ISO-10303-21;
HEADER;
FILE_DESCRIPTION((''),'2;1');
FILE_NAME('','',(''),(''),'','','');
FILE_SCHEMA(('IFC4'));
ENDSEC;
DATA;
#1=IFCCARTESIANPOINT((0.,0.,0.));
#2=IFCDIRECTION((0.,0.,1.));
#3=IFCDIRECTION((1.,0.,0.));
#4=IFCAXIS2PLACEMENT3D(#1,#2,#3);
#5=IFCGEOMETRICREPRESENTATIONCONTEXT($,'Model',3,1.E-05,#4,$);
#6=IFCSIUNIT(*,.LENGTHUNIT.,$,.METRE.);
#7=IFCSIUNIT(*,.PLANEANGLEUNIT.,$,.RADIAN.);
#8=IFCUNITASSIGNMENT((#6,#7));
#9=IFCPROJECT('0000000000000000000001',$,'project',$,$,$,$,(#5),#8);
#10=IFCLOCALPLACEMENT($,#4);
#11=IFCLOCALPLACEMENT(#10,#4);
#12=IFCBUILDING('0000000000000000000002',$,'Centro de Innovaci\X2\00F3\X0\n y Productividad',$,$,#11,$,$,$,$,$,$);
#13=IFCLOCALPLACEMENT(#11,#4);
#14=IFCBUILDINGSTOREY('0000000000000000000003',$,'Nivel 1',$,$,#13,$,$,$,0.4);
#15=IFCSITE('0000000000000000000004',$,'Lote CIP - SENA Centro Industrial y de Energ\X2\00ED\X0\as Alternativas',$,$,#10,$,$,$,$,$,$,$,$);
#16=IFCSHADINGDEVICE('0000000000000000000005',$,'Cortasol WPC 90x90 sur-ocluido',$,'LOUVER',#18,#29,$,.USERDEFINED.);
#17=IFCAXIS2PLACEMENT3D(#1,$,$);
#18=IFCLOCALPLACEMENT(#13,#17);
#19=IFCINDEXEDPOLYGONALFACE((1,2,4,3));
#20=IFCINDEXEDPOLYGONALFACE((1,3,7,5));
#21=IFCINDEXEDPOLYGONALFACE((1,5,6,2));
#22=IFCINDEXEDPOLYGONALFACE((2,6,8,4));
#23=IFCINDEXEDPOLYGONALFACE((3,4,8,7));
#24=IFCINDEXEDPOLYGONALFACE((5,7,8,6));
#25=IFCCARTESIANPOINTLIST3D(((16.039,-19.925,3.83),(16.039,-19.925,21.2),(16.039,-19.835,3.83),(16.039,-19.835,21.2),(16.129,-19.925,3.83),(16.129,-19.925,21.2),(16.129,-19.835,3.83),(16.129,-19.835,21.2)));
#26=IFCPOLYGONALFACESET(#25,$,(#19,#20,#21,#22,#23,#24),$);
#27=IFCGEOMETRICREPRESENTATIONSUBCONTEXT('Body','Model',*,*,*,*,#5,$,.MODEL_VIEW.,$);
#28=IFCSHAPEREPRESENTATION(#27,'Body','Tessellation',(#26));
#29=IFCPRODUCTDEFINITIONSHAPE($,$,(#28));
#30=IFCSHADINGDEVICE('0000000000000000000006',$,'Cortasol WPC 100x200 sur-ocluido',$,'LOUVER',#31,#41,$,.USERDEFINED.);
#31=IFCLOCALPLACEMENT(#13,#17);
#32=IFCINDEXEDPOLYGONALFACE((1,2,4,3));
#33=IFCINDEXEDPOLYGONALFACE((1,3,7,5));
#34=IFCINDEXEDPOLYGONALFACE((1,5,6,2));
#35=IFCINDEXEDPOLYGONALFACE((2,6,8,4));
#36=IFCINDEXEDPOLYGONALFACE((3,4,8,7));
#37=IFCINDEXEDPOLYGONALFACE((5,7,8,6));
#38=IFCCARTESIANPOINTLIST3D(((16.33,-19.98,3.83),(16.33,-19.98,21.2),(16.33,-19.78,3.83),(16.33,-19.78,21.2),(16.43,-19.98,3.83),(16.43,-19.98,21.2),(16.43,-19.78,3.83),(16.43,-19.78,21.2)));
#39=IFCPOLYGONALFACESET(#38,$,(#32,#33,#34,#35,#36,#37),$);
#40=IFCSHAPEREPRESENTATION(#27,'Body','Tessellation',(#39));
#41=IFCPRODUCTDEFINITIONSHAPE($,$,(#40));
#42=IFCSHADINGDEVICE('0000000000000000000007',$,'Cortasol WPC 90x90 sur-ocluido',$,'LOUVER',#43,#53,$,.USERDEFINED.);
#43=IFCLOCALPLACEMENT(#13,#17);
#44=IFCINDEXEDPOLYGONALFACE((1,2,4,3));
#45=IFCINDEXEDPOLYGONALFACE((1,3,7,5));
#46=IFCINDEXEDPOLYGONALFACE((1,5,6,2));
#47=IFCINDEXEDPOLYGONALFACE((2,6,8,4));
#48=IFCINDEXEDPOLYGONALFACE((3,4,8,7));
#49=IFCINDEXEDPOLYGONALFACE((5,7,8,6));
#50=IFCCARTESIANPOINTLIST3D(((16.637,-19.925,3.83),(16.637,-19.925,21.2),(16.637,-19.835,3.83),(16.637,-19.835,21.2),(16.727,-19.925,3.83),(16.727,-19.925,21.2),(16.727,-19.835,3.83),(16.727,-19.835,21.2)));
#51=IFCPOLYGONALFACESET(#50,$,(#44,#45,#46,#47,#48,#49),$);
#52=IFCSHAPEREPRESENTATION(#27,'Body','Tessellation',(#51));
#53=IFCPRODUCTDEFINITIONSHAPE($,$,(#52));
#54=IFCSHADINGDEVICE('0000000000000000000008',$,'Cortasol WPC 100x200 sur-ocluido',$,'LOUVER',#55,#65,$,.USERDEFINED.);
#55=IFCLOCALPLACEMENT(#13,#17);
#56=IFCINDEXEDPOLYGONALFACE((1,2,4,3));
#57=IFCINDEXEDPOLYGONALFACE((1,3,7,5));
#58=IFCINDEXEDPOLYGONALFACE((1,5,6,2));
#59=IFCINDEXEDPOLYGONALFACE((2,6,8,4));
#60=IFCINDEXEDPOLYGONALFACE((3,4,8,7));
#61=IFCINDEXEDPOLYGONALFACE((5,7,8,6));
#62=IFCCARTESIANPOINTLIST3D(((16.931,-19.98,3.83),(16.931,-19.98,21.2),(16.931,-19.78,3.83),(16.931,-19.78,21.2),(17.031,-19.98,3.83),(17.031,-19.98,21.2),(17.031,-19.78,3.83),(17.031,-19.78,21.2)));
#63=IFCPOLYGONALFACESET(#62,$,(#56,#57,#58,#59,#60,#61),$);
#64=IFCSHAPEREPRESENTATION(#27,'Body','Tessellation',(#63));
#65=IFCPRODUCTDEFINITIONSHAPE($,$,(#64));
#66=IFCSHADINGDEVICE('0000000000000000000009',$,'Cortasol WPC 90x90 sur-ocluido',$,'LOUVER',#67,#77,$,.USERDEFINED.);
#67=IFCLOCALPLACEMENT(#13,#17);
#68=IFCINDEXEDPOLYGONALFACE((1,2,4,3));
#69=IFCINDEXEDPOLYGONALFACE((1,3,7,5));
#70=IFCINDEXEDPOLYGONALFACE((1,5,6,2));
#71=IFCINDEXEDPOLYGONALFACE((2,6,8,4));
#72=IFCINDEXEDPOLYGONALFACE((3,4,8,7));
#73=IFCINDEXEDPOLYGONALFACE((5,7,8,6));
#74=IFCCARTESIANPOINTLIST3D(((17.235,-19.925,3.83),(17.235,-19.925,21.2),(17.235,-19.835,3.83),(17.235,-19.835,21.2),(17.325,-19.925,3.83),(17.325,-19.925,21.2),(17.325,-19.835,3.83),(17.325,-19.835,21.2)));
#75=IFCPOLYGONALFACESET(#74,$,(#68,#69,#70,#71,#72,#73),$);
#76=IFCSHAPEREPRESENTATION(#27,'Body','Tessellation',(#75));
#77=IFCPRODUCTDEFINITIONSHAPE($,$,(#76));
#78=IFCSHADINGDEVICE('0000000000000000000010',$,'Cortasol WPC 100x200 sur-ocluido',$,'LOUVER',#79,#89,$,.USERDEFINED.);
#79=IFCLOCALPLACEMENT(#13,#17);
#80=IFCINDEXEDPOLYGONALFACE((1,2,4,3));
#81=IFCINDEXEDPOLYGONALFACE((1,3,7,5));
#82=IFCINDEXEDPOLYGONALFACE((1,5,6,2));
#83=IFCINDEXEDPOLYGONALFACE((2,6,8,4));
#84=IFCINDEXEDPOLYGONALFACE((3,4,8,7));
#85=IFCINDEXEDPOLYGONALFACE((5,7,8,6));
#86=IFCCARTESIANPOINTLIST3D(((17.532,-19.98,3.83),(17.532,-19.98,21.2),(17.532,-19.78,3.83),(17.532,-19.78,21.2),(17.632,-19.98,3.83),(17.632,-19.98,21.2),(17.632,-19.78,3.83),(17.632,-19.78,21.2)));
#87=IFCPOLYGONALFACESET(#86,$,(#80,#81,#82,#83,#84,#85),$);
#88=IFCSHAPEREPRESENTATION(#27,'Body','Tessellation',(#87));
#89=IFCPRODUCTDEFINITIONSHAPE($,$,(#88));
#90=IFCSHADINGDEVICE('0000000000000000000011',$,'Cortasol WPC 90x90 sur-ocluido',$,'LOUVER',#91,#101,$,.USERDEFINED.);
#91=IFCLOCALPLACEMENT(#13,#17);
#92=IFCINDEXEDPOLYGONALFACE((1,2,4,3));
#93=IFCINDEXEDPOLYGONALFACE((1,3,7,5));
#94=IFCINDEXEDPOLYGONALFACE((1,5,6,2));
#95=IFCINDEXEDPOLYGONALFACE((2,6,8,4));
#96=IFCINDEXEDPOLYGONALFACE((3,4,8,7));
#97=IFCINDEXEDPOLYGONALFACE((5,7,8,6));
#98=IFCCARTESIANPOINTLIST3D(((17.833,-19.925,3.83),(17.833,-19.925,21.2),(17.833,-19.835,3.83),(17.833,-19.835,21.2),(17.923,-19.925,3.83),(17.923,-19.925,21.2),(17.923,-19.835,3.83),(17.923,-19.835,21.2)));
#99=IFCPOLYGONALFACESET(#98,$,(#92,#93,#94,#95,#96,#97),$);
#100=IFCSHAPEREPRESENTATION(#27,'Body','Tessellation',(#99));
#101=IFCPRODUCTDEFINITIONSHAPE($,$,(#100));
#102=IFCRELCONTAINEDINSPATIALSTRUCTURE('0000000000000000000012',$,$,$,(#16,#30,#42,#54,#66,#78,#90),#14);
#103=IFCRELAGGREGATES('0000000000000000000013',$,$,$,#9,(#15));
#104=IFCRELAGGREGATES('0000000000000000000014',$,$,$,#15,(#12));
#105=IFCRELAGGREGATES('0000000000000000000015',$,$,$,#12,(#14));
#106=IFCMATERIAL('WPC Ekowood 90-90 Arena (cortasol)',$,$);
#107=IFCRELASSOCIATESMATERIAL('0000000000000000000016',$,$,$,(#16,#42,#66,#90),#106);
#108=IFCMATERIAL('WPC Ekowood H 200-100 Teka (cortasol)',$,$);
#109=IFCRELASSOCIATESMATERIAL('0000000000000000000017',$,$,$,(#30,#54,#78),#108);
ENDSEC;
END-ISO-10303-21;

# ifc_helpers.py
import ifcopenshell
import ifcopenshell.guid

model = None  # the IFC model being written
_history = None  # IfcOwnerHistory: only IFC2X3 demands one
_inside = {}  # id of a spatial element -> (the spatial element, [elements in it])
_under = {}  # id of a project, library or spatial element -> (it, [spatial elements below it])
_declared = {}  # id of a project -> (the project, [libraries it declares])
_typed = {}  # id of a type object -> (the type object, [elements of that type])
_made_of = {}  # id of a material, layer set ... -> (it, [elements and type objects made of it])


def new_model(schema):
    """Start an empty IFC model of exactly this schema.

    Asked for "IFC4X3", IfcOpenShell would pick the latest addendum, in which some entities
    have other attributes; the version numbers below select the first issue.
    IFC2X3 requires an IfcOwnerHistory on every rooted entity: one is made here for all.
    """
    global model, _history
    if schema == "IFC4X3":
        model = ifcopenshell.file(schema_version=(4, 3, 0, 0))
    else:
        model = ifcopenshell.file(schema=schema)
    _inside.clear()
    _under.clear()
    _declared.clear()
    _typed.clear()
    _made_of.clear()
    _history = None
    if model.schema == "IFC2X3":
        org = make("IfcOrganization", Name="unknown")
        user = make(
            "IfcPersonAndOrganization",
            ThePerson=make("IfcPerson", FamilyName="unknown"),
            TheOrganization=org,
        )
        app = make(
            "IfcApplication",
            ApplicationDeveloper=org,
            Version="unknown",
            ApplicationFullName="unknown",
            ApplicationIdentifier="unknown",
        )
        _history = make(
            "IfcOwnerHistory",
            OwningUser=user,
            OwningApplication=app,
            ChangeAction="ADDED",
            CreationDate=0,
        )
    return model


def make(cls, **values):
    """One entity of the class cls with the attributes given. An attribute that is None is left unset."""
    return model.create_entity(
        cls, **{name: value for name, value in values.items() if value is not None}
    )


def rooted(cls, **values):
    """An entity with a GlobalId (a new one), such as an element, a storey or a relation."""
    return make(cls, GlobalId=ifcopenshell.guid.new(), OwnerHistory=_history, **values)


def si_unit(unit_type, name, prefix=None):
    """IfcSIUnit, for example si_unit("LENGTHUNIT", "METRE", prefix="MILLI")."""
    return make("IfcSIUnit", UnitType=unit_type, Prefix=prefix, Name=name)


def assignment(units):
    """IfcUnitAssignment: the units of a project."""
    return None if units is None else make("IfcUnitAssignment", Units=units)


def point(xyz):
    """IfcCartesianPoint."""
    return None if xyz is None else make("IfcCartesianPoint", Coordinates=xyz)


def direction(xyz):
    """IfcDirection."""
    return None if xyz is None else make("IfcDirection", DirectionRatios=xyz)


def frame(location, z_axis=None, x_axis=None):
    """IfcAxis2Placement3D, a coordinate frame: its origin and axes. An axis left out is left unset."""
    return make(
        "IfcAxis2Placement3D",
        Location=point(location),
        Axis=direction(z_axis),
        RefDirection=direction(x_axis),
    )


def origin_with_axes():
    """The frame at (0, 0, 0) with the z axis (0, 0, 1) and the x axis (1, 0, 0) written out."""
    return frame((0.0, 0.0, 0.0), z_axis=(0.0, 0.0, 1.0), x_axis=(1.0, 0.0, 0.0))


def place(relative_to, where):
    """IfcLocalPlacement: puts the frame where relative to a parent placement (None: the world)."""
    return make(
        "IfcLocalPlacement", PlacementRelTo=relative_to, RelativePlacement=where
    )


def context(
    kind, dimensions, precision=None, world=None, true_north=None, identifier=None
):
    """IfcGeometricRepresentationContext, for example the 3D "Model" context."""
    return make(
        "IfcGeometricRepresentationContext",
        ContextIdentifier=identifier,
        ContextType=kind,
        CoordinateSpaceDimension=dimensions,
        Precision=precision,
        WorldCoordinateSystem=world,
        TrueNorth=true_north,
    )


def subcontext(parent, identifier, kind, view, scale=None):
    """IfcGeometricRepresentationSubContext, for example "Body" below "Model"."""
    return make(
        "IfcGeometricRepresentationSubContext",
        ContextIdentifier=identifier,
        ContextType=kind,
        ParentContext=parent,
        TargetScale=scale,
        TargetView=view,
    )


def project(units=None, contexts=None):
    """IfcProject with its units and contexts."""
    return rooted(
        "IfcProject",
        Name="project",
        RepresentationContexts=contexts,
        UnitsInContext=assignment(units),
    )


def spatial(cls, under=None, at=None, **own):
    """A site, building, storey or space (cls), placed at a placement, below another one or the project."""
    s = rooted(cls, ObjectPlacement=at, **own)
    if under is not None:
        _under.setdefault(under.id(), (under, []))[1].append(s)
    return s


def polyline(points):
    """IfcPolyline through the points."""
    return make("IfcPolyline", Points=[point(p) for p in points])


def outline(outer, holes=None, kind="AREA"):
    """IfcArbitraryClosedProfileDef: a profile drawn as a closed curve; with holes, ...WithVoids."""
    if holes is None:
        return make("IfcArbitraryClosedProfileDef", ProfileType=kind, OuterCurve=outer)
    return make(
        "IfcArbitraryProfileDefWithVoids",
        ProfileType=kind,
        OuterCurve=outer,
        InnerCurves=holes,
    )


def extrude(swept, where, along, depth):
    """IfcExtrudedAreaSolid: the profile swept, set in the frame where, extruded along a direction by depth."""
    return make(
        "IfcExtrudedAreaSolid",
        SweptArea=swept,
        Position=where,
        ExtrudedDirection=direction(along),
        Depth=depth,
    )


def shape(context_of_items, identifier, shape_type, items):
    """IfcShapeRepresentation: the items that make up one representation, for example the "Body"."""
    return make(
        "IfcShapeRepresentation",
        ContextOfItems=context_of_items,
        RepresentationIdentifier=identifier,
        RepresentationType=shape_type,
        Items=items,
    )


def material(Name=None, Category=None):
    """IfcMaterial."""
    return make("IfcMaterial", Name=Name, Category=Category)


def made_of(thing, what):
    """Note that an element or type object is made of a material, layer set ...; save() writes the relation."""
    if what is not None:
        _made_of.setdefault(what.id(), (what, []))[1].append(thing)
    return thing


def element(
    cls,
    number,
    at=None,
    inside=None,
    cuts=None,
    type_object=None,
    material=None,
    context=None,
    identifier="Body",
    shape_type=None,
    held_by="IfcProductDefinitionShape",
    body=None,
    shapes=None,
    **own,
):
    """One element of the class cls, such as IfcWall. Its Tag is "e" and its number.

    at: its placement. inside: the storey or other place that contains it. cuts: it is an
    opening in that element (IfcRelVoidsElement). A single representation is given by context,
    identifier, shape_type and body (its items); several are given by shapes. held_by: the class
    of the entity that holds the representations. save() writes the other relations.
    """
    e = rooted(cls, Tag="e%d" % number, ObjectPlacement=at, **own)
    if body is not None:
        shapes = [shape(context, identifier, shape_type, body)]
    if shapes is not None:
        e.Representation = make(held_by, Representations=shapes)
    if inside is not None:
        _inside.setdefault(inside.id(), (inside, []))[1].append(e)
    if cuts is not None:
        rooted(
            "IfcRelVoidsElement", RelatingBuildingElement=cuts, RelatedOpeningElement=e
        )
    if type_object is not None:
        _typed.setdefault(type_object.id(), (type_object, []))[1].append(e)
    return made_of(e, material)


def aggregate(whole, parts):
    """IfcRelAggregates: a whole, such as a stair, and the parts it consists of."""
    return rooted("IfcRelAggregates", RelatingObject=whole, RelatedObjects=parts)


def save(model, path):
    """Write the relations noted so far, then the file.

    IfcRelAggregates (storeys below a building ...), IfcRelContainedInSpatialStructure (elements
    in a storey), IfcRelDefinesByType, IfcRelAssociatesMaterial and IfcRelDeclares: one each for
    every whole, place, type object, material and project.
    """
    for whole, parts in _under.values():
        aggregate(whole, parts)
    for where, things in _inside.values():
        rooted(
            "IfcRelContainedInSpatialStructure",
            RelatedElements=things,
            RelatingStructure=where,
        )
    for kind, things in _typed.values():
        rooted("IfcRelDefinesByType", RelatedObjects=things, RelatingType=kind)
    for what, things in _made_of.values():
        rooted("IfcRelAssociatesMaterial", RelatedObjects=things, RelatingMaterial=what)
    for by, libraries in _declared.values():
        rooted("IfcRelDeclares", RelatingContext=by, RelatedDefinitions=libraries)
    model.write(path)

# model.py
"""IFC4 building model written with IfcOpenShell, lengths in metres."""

from ifc_helpers import new_model, si_unit, frame, origin_with_axes, place, context, subcontext, project, spatial, polyline, outline, extrude, material, element, save


model = new_model("IFC4")

# Units and contexts
model_context = context("Model", 3, precision=1e-05, world=origin_with_axes())
body_context = subcontext(model_context, "Body", "Model", "MODEL_VIEW")
ifc_project = project(units=[si_unit("LENGTHUNIT", "METRE"), si_unit("PLANEANGLEUNIT", "RADIAN")], contexts=[model_context])

# Site, building, storey
site_placement = place(None, origin_with_axes())
site = spatial("IfcSite", under=ifc_project, at=site_placement, Name="Lote CIP - SENA Centro Industrial y de Energías Alternativas")
building_placement = place(site_placement, origin_with_axes())
building = spatial("IfcBuilding", under=site, at=building_placement, Name="Centro de Innovación y Productividad")
storey_placement = place(building_placement, origin_with_axes())
storey = spatial("IfcBuildingStorey", under=building, at=storey_placement, Name="Nivel 1", Elevation=0.4)

# Shading devices
ifc_material_1 = material(Name="WPC Ekowood H 200-100 Teka (cortasol)")
ifc_material_2 = material(Name="WPC Ekowood 90-90 Arena (cortasol)")
shading_device_1_placement = place(storey_placement, origin_with_axes())
element("IfcShadingDevice", 1, at=shading_device_1_placement, inside=storey, material=ifc_material_2, Name="Cortasol WPC 90x90 sur-ocluido", ObjectType="LOUVER", PredefinedType="USERDEFINED", context=body_context, shape_type="SweptSolid", body=[
    extrude(outline(polyline([(16.039, -19.925), (16.039, -19.835), (16.129, -19.835), (16.129, -19.925), (16.039, -19.925)])), frame((0.0, 0.0, 3.83)), (0.0, 0.0, 1.0), 17.37),
])
shading_device_2_placement = place(storey_placement, origin_with_axes())
element("IfcShadingDevice", 2, at=shading_device_2_placement, inside=storey, material=ifc_material_1, Name="Cortasol WPC 100x200 sur-ocluido", ObjectType="LOUVER", PredefinedType="USERDEFINED", context=body_context, shape_type="SweptSolid", body=[
    extrude(outline(polyline([(16.33, -19.98), (16.33, -19.78), (16.43, -19.78), (16.43, -19.98), (16.33, -19.98)])), frame((0.0, 0.0, 3.83)), (0.0, 0.0, 1.0), 17.37),
])
shading_device_3_placement = place(storey_placement, origin_with_axes())
element("IfcShadingDevice", 3, at=shading_device_3_placement, inside=storey, material=ifc_material_2, Name="Cortasol WPC 90x90 sur-ocluido", ObjectType="LOUVER", PredefinedType="USERDEFINED", context=body_context, shape_type="SweptSolid", body=[
    extrude(outline(polyline([(16.637, -19.925), (16.637, -19.835), (16.727, -19.835), (16.727, -19.925), (16.637, -19.925)])), frame((0.0, 0.0, 3.83)), (0.0, 0.0, 1.0), 17.37),
])
shading_device_4_placement = place(storey_placement, origin_with_axes())
element("IfcShadingDevice", 4, at=shading_device_4_placement, inside=storey, material=ifc_material_1, Name="Cortasol WPC 100x200 sur-ocluido", ObjectType="LOUVER", PredefinedType="USERDEFINED", context=body_context, shape_type="SweptSolid", body=[
    extrude(outline(polyline([(16.931, -19.98), (16.931, -19.78), (17.031, -19.78), (17.031, -19.98), (16.931, -19.98)])), frame((0.0, 0.0, 3.83)), (0.0, 0.0, 1.0), 17.37),
])
shading_device_5_placement = place(storey_placement, origin_with_axes())
element("IfcShadingDevice", 5, at=shading_device_5_placement, inside=storey, material=ifc_material_2, Name="Cortasol WPC 90x90 sur-ocluido", ObjectType="LOUVER", PredefinedType="USERDEFINED", context=body_context, shape_type="SweptSolid", body=[
    extrude(outline(polyline([(17.235, -19.925), (17.235, -19.835), (17.325, -19.835), (17.325, -19.925), (17.235, -19.925)])), frame((0.0, 0.0, 3.83)), (0.0, 0.0, 1.0), 17.37),
])
shading_device_6_placement = place(storey_placement, origin_with_axes())
element("IfcShadingDevice", 6, at=shading_device_6_placement, inside=storey, material=ifc_material_1, Name="Cortasol WPC 100x200 sur-ocluido", ObjectType="LOUVER", PredefinedType="USERDEFINED", context=body_context, shape_type="SweptSolid", body=[
    extrude(outline(polyline([(17.532, -19.98), (17.532, -19.78), (17.632, -19.78), (17.632, -19.98), (17.532, -19.98)])), frame((0.0, 0.0, 3.83)), (0.0, 0.0, 1.0), 17.37),
])
shading_device_7_placement = place(storey_placement, origin_with_axes())
element("IfcShadingDevice", 7, at=shading_device_7_placement, inside=storey, material=ifc_material_2, Name="Cortasol WPC 90x90 sur-ocluido", ObjectType="LOUVER", PredefinedType="USERDEFINED", context=body_context, shape_type="SweptSolid", body=[
    extrude(outline(polyline([(17.833, -19.925), (17.833, -19.835), (17.923, -19.835), (17.923, -19.925), (17.833, -19.925)])), frame((0.0, 0.0, 3.83)), (0.0, 0.0, 1.0), 17.37),
])

save(model, "model.ifc")
